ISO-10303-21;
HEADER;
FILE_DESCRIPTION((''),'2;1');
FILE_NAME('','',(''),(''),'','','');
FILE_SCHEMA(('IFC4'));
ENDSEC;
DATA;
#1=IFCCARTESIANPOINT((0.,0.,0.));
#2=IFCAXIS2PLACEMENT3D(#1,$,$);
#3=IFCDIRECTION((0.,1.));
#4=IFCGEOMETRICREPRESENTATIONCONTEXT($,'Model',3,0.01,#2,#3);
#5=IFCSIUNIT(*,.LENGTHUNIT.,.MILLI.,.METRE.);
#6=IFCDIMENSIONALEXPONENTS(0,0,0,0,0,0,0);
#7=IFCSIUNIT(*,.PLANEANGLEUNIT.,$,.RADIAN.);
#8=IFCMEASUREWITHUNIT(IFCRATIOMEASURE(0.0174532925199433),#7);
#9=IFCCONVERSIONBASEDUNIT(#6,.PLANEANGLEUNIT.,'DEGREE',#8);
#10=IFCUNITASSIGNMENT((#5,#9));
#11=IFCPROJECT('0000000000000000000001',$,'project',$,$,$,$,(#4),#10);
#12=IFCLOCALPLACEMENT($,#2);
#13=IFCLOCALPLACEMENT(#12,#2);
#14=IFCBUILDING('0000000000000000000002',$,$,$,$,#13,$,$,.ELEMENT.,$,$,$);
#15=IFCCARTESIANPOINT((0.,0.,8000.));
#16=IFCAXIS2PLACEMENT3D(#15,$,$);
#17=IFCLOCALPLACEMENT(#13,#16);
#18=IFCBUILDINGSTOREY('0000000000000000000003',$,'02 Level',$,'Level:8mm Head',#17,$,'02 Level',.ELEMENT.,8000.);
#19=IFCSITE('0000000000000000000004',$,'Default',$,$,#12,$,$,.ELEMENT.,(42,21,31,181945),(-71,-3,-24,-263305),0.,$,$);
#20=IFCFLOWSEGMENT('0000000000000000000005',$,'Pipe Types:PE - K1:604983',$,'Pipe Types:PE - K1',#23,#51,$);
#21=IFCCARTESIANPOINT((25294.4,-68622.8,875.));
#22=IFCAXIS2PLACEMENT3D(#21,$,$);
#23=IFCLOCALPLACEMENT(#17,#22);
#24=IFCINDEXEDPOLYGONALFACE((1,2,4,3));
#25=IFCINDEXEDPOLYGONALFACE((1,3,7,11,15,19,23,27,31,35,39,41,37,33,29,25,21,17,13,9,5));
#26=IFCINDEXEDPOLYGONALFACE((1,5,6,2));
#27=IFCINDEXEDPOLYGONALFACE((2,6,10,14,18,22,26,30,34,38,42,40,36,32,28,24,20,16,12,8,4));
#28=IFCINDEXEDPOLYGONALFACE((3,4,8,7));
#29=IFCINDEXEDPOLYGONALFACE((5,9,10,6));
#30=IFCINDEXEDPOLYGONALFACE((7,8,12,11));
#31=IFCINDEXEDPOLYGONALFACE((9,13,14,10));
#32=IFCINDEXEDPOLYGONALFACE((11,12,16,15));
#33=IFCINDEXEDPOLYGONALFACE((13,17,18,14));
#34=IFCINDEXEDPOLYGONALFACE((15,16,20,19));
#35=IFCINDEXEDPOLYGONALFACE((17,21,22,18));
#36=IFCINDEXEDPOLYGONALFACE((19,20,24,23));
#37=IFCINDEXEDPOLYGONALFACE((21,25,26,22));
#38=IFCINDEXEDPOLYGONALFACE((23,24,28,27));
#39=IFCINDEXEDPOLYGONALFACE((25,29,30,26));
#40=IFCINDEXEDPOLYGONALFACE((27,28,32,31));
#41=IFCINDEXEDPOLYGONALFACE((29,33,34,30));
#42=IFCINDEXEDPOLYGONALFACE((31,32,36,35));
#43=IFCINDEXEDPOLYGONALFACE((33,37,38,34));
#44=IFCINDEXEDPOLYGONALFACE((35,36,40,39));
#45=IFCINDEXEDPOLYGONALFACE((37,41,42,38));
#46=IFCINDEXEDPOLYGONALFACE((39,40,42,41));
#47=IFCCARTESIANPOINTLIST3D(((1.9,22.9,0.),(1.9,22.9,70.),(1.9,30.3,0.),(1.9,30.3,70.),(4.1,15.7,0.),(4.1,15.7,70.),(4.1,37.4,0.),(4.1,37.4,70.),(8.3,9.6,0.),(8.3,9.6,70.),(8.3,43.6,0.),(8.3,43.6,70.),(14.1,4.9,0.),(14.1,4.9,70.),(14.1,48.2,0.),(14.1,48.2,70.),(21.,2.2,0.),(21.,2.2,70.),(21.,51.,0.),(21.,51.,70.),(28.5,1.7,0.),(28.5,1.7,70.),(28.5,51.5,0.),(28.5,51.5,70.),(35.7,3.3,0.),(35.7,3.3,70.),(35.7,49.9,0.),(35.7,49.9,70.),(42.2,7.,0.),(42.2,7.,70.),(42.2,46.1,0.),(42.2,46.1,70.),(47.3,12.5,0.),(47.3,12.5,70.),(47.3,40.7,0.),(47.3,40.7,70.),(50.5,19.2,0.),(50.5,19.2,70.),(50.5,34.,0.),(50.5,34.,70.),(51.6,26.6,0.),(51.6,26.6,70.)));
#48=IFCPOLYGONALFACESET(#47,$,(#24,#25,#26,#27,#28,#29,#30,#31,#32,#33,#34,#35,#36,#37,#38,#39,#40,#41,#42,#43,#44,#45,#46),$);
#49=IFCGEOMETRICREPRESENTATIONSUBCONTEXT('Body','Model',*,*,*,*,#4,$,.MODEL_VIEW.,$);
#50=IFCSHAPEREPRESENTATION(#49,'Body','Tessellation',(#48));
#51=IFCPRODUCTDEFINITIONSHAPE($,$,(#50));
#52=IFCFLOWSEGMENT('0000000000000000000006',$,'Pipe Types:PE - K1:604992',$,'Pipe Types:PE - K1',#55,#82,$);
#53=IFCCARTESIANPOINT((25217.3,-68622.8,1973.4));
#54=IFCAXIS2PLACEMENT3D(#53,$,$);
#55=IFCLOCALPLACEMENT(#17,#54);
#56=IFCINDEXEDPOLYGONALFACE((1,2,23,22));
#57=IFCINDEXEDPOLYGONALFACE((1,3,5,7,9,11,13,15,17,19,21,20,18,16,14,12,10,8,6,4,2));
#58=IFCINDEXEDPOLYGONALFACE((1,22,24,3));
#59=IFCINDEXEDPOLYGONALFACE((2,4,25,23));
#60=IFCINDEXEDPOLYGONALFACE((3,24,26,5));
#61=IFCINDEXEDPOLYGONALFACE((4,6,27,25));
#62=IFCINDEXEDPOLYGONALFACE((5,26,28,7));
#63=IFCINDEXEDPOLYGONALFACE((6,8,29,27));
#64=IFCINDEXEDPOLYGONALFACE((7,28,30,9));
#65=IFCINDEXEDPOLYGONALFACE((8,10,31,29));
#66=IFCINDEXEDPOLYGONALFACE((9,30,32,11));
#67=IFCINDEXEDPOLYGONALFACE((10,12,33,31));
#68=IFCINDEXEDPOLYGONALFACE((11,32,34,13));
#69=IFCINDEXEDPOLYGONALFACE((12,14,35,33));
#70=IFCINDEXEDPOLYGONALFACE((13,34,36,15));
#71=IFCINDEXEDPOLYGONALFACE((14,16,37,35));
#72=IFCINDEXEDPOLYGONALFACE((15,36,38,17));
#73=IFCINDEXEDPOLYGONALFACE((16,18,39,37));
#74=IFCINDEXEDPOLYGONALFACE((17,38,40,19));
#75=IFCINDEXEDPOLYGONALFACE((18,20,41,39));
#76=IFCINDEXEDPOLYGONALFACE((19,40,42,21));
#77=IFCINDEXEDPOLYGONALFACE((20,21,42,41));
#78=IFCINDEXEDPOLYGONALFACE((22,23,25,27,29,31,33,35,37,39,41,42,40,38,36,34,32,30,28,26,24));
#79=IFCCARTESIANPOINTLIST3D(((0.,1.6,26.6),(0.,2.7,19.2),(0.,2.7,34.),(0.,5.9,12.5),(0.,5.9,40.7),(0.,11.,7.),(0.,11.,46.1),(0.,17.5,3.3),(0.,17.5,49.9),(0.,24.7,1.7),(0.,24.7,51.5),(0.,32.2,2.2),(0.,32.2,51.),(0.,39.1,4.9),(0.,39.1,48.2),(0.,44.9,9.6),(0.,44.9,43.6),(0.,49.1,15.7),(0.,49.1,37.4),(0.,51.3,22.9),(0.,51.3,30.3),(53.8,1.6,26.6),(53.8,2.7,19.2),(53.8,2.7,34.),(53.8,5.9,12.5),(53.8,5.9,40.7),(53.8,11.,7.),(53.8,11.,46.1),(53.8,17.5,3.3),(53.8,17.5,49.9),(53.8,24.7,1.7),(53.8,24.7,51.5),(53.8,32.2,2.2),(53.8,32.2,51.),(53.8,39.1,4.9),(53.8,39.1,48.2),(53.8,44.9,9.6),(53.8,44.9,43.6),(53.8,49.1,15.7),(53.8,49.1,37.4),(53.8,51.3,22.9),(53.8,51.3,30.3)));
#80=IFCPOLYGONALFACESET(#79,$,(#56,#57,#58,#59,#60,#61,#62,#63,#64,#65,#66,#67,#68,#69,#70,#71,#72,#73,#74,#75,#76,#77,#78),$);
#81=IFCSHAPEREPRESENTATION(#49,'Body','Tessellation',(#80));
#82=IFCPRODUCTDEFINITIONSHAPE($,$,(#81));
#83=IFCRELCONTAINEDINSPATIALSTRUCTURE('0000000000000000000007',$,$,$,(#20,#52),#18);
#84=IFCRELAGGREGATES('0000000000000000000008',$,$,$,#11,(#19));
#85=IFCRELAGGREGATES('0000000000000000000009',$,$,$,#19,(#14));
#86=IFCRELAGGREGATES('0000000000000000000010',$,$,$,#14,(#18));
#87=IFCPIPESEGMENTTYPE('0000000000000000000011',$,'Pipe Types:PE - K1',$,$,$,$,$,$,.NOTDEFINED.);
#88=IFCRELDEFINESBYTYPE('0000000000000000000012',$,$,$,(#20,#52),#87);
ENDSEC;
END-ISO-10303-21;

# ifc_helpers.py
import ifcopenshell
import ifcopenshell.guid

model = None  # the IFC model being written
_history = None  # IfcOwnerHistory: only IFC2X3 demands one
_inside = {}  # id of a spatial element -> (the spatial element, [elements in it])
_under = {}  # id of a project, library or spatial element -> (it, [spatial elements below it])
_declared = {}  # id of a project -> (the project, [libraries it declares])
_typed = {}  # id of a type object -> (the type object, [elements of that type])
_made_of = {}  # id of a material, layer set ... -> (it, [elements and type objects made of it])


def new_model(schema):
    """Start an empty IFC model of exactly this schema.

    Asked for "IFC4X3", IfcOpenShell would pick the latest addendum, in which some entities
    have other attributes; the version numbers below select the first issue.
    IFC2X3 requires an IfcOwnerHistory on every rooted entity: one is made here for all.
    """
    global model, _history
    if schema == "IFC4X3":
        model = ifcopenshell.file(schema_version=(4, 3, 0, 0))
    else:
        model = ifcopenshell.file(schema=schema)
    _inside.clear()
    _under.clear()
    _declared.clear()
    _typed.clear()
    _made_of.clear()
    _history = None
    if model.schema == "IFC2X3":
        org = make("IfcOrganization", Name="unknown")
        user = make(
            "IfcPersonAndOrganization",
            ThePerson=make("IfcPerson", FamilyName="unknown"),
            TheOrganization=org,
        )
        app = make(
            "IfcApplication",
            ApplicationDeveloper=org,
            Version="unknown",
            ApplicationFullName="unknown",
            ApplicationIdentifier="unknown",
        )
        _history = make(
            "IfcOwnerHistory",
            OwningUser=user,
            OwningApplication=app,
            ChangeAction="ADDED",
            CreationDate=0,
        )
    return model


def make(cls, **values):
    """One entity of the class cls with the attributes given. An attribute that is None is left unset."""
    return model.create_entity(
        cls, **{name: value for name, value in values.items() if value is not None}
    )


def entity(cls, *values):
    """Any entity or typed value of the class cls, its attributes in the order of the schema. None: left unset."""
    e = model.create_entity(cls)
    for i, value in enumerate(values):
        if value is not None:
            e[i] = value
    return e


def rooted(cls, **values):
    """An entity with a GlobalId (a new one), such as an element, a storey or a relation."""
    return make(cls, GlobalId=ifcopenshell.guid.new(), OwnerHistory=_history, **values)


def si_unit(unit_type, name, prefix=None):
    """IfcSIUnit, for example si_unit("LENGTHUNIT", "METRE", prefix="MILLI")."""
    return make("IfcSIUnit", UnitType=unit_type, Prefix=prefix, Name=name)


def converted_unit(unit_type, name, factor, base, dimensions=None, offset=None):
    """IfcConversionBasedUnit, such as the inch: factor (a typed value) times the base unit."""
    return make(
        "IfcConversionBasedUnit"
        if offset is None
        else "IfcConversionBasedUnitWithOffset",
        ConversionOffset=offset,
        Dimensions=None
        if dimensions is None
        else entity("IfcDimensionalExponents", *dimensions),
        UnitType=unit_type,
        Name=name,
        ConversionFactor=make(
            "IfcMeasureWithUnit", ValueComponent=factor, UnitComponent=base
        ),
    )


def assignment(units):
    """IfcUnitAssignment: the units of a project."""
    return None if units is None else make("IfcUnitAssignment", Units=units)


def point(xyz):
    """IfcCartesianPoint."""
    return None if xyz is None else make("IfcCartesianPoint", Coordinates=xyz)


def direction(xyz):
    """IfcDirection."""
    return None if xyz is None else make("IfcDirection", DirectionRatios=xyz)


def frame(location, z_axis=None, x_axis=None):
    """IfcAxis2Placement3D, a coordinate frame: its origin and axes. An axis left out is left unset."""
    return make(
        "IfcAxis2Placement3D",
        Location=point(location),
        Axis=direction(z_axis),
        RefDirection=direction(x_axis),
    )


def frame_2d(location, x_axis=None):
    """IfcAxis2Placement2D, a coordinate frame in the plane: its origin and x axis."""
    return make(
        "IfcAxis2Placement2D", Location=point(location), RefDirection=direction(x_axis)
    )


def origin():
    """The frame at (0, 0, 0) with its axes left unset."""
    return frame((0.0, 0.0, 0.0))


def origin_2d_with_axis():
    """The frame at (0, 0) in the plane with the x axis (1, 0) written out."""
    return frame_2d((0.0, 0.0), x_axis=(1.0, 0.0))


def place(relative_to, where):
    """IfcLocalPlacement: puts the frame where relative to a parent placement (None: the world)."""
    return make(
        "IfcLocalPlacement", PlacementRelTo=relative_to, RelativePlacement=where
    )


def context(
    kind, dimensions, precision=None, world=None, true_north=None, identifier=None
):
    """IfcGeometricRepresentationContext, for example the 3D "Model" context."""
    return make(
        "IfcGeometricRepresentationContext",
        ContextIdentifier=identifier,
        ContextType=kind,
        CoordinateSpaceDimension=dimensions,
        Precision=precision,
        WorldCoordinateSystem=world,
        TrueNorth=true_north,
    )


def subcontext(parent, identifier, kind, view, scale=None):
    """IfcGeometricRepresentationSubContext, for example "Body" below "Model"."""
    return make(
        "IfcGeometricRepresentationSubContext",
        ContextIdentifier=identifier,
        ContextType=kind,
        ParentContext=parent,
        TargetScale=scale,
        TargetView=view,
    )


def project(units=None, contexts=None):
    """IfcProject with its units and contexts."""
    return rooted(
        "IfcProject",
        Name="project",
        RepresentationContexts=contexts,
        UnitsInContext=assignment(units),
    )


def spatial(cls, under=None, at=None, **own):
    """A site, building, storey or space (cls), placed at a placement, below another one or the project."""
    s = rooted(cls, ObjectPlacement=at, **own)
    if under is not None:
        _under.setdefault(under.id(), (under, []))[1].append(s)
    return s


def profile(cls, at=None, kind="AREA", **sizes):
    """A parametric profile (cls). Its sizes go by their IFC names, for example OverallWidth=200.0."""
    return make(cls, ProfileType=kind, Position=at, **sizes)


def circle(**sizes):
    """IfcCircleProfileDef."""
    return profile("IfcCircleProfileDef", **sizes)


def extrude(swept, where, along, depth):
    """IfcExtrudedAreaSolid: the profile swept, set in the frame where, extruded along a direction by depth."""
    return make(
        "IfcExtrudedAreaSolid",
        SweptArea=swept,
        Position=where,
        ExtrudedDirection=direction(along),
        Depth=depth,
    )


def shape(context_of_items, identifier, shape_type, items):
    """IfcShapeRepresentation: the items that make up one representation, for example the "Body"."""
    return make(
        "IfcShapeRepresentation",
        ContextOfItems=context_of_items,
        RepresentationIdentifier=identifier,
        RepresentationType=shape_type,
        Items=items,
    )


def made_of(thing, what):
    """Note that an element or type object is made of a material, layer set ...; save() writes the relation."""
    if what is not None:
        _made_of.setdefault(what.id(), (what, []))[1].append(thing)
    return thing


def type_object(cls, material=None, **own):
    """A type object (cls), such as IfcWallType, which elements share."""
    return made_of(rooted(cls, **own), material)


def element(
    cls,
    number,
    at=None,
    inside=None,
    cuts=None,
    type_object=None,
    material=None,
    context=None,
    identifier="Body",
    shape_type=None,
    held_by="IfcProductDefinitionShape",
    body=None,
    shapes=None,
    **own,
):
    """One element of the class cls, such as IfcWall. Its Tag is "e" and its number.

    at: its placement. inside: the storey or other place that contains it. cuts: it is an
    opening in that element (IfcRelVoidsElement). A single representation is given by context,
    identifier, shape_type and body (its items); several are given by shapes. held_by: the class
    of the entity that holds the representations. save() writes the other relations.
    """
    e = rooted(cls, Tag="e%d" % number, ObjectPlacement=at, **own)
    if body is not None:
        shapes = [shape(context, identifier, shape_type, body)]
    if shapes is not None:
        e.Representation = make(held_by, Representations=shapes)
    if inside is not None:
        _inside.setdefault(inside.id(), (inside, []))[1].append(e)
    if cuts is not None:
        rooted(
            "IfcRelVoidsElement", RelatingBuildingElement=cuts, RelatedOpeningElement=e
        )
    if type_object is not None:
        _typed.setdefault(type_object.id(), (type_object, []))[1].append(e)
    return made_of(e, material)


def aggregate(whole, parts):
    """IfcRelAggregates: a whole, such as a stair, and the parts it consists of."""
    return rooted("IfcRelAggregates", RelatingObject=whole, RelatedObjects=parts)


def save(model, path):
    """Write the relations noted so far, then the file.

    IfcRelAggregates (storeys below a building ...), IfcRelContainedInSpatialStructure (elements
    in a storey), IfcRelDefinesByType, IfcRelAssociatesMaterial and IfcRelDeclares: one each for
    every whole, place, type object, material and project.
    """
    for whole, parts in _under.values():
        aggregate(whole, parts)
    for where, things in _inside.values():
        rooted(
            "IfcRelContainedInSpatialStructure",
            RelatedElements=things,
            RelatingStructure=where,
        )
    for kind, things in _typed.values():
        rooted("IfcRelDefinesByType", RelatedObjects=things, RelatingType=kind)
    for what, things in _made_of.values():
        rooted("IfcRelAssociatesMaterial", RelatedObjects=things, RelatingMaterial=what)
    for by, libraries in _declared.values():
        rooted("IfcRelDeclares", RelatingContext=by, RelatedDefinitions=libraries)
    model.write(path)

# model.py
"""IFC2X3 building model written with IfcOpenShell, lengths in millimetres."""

from ifc_helpers import new_model, entity, si_unit, converted_unit, direction, frame, frame_2d, origin, origin_2d_with_axis, place, context, subcontext, project, spatial, circle, extrude, type_object, element, save


model = new_model("IFC2X3")

# Units and contexts
model_context = context("Model", 3, precision=0.01, world=origin(), true_north=direction((0.0, 1.0)))
body_context = subcontext(model_context, "Body", "Model", "MODEL_VIEW")
ifc_project = project(units=[si_unit("LENGTHUNIT", "METRE", prefix="MILLI"), converted_unit("PLANEANGLEUNIT", "DEGREE", entity("IfcRatioMeasure", 0.0174532925199433), si_unit("PLANEANGLEUNIT", "RADIAN"), dimensions=[0, 0, 0, 0, 0, 0, 0])], contexts=[model_context])

# Site, building, storey
site_placement = place(None, origin())
site = spatial("IfcSite", under=ifc_project, at=site_placement, Name="Default", CompositionType="ELEMENT", RefLatitude=(42, 21, 31, 181945), RefLongitude=(-71, -3, -24, -263305), RefElevation=0.0)
building_placement = place(site_placement, origin())
building = spatial("IfcBuilding", under=site, at=building_placement, CompositionType="ELEMENT")
storey_placement = place(building_placement, frame((0.0, 0.0, 8000.0)))
storey = spatial("IfcBuildingStorey", under=building, at=storey_placement, Name="02 Level", ObjectType="Level:8mm Head", LongName="02 Level", CompositionType="ELEMENT", Elevation=8000.0)

# Flow segments
pipe_segment_type_1 = type_object("IfcPipeSegmentType", Name="Pipe Types:PE - K1", PredefinedType="NOTDEFINED")
flow_segment_1_placement = place(storey_placement, frame((25294.4, -68622.8, 875.0)))
element("IfcFlowSegment", 1, at=flow_segment_1_placement, inside=storey, type_object=pipe_segment_type_1, Name="Pipe Types:PE - K1:604983", ObjectType="Pipe Types:PE - K1", context=body_context, shape_type="SweptSolid", body=[
    extrude(circle(Radius=25.0, at=origin_2d_with_axis()), frame((26.6, 26.6, 0.0)), (0.0, 0.0, 1.0), 70.0),
])
flow_segment_2_placement = place(storey_placement, frame((25217.3, -68622.8, 1973.4)))
element("IfcFlowSegment", 2, at=flow_segment_2_placement, inside=storey, type_object=pipe_segment_type_1, Name="Pipe Types:PE - K1:604992", ObjectType="Pipe Types:PE - K1", context=body_context, shape_type="SweptSolid", body=[
    extrude(circle(Radius=25.0, at=frame_2d((0.0, 0.0), x_axis=(1.0, 0.0))), frame((0.0, 26.6, 26.6), z_axis=(1.0, 0.0, 0.0), x_axis=(0.0, -1.0, 0.0)), (0.0, 0.0, 1.0), 53.8),
])

save(model, "model.ifc")
